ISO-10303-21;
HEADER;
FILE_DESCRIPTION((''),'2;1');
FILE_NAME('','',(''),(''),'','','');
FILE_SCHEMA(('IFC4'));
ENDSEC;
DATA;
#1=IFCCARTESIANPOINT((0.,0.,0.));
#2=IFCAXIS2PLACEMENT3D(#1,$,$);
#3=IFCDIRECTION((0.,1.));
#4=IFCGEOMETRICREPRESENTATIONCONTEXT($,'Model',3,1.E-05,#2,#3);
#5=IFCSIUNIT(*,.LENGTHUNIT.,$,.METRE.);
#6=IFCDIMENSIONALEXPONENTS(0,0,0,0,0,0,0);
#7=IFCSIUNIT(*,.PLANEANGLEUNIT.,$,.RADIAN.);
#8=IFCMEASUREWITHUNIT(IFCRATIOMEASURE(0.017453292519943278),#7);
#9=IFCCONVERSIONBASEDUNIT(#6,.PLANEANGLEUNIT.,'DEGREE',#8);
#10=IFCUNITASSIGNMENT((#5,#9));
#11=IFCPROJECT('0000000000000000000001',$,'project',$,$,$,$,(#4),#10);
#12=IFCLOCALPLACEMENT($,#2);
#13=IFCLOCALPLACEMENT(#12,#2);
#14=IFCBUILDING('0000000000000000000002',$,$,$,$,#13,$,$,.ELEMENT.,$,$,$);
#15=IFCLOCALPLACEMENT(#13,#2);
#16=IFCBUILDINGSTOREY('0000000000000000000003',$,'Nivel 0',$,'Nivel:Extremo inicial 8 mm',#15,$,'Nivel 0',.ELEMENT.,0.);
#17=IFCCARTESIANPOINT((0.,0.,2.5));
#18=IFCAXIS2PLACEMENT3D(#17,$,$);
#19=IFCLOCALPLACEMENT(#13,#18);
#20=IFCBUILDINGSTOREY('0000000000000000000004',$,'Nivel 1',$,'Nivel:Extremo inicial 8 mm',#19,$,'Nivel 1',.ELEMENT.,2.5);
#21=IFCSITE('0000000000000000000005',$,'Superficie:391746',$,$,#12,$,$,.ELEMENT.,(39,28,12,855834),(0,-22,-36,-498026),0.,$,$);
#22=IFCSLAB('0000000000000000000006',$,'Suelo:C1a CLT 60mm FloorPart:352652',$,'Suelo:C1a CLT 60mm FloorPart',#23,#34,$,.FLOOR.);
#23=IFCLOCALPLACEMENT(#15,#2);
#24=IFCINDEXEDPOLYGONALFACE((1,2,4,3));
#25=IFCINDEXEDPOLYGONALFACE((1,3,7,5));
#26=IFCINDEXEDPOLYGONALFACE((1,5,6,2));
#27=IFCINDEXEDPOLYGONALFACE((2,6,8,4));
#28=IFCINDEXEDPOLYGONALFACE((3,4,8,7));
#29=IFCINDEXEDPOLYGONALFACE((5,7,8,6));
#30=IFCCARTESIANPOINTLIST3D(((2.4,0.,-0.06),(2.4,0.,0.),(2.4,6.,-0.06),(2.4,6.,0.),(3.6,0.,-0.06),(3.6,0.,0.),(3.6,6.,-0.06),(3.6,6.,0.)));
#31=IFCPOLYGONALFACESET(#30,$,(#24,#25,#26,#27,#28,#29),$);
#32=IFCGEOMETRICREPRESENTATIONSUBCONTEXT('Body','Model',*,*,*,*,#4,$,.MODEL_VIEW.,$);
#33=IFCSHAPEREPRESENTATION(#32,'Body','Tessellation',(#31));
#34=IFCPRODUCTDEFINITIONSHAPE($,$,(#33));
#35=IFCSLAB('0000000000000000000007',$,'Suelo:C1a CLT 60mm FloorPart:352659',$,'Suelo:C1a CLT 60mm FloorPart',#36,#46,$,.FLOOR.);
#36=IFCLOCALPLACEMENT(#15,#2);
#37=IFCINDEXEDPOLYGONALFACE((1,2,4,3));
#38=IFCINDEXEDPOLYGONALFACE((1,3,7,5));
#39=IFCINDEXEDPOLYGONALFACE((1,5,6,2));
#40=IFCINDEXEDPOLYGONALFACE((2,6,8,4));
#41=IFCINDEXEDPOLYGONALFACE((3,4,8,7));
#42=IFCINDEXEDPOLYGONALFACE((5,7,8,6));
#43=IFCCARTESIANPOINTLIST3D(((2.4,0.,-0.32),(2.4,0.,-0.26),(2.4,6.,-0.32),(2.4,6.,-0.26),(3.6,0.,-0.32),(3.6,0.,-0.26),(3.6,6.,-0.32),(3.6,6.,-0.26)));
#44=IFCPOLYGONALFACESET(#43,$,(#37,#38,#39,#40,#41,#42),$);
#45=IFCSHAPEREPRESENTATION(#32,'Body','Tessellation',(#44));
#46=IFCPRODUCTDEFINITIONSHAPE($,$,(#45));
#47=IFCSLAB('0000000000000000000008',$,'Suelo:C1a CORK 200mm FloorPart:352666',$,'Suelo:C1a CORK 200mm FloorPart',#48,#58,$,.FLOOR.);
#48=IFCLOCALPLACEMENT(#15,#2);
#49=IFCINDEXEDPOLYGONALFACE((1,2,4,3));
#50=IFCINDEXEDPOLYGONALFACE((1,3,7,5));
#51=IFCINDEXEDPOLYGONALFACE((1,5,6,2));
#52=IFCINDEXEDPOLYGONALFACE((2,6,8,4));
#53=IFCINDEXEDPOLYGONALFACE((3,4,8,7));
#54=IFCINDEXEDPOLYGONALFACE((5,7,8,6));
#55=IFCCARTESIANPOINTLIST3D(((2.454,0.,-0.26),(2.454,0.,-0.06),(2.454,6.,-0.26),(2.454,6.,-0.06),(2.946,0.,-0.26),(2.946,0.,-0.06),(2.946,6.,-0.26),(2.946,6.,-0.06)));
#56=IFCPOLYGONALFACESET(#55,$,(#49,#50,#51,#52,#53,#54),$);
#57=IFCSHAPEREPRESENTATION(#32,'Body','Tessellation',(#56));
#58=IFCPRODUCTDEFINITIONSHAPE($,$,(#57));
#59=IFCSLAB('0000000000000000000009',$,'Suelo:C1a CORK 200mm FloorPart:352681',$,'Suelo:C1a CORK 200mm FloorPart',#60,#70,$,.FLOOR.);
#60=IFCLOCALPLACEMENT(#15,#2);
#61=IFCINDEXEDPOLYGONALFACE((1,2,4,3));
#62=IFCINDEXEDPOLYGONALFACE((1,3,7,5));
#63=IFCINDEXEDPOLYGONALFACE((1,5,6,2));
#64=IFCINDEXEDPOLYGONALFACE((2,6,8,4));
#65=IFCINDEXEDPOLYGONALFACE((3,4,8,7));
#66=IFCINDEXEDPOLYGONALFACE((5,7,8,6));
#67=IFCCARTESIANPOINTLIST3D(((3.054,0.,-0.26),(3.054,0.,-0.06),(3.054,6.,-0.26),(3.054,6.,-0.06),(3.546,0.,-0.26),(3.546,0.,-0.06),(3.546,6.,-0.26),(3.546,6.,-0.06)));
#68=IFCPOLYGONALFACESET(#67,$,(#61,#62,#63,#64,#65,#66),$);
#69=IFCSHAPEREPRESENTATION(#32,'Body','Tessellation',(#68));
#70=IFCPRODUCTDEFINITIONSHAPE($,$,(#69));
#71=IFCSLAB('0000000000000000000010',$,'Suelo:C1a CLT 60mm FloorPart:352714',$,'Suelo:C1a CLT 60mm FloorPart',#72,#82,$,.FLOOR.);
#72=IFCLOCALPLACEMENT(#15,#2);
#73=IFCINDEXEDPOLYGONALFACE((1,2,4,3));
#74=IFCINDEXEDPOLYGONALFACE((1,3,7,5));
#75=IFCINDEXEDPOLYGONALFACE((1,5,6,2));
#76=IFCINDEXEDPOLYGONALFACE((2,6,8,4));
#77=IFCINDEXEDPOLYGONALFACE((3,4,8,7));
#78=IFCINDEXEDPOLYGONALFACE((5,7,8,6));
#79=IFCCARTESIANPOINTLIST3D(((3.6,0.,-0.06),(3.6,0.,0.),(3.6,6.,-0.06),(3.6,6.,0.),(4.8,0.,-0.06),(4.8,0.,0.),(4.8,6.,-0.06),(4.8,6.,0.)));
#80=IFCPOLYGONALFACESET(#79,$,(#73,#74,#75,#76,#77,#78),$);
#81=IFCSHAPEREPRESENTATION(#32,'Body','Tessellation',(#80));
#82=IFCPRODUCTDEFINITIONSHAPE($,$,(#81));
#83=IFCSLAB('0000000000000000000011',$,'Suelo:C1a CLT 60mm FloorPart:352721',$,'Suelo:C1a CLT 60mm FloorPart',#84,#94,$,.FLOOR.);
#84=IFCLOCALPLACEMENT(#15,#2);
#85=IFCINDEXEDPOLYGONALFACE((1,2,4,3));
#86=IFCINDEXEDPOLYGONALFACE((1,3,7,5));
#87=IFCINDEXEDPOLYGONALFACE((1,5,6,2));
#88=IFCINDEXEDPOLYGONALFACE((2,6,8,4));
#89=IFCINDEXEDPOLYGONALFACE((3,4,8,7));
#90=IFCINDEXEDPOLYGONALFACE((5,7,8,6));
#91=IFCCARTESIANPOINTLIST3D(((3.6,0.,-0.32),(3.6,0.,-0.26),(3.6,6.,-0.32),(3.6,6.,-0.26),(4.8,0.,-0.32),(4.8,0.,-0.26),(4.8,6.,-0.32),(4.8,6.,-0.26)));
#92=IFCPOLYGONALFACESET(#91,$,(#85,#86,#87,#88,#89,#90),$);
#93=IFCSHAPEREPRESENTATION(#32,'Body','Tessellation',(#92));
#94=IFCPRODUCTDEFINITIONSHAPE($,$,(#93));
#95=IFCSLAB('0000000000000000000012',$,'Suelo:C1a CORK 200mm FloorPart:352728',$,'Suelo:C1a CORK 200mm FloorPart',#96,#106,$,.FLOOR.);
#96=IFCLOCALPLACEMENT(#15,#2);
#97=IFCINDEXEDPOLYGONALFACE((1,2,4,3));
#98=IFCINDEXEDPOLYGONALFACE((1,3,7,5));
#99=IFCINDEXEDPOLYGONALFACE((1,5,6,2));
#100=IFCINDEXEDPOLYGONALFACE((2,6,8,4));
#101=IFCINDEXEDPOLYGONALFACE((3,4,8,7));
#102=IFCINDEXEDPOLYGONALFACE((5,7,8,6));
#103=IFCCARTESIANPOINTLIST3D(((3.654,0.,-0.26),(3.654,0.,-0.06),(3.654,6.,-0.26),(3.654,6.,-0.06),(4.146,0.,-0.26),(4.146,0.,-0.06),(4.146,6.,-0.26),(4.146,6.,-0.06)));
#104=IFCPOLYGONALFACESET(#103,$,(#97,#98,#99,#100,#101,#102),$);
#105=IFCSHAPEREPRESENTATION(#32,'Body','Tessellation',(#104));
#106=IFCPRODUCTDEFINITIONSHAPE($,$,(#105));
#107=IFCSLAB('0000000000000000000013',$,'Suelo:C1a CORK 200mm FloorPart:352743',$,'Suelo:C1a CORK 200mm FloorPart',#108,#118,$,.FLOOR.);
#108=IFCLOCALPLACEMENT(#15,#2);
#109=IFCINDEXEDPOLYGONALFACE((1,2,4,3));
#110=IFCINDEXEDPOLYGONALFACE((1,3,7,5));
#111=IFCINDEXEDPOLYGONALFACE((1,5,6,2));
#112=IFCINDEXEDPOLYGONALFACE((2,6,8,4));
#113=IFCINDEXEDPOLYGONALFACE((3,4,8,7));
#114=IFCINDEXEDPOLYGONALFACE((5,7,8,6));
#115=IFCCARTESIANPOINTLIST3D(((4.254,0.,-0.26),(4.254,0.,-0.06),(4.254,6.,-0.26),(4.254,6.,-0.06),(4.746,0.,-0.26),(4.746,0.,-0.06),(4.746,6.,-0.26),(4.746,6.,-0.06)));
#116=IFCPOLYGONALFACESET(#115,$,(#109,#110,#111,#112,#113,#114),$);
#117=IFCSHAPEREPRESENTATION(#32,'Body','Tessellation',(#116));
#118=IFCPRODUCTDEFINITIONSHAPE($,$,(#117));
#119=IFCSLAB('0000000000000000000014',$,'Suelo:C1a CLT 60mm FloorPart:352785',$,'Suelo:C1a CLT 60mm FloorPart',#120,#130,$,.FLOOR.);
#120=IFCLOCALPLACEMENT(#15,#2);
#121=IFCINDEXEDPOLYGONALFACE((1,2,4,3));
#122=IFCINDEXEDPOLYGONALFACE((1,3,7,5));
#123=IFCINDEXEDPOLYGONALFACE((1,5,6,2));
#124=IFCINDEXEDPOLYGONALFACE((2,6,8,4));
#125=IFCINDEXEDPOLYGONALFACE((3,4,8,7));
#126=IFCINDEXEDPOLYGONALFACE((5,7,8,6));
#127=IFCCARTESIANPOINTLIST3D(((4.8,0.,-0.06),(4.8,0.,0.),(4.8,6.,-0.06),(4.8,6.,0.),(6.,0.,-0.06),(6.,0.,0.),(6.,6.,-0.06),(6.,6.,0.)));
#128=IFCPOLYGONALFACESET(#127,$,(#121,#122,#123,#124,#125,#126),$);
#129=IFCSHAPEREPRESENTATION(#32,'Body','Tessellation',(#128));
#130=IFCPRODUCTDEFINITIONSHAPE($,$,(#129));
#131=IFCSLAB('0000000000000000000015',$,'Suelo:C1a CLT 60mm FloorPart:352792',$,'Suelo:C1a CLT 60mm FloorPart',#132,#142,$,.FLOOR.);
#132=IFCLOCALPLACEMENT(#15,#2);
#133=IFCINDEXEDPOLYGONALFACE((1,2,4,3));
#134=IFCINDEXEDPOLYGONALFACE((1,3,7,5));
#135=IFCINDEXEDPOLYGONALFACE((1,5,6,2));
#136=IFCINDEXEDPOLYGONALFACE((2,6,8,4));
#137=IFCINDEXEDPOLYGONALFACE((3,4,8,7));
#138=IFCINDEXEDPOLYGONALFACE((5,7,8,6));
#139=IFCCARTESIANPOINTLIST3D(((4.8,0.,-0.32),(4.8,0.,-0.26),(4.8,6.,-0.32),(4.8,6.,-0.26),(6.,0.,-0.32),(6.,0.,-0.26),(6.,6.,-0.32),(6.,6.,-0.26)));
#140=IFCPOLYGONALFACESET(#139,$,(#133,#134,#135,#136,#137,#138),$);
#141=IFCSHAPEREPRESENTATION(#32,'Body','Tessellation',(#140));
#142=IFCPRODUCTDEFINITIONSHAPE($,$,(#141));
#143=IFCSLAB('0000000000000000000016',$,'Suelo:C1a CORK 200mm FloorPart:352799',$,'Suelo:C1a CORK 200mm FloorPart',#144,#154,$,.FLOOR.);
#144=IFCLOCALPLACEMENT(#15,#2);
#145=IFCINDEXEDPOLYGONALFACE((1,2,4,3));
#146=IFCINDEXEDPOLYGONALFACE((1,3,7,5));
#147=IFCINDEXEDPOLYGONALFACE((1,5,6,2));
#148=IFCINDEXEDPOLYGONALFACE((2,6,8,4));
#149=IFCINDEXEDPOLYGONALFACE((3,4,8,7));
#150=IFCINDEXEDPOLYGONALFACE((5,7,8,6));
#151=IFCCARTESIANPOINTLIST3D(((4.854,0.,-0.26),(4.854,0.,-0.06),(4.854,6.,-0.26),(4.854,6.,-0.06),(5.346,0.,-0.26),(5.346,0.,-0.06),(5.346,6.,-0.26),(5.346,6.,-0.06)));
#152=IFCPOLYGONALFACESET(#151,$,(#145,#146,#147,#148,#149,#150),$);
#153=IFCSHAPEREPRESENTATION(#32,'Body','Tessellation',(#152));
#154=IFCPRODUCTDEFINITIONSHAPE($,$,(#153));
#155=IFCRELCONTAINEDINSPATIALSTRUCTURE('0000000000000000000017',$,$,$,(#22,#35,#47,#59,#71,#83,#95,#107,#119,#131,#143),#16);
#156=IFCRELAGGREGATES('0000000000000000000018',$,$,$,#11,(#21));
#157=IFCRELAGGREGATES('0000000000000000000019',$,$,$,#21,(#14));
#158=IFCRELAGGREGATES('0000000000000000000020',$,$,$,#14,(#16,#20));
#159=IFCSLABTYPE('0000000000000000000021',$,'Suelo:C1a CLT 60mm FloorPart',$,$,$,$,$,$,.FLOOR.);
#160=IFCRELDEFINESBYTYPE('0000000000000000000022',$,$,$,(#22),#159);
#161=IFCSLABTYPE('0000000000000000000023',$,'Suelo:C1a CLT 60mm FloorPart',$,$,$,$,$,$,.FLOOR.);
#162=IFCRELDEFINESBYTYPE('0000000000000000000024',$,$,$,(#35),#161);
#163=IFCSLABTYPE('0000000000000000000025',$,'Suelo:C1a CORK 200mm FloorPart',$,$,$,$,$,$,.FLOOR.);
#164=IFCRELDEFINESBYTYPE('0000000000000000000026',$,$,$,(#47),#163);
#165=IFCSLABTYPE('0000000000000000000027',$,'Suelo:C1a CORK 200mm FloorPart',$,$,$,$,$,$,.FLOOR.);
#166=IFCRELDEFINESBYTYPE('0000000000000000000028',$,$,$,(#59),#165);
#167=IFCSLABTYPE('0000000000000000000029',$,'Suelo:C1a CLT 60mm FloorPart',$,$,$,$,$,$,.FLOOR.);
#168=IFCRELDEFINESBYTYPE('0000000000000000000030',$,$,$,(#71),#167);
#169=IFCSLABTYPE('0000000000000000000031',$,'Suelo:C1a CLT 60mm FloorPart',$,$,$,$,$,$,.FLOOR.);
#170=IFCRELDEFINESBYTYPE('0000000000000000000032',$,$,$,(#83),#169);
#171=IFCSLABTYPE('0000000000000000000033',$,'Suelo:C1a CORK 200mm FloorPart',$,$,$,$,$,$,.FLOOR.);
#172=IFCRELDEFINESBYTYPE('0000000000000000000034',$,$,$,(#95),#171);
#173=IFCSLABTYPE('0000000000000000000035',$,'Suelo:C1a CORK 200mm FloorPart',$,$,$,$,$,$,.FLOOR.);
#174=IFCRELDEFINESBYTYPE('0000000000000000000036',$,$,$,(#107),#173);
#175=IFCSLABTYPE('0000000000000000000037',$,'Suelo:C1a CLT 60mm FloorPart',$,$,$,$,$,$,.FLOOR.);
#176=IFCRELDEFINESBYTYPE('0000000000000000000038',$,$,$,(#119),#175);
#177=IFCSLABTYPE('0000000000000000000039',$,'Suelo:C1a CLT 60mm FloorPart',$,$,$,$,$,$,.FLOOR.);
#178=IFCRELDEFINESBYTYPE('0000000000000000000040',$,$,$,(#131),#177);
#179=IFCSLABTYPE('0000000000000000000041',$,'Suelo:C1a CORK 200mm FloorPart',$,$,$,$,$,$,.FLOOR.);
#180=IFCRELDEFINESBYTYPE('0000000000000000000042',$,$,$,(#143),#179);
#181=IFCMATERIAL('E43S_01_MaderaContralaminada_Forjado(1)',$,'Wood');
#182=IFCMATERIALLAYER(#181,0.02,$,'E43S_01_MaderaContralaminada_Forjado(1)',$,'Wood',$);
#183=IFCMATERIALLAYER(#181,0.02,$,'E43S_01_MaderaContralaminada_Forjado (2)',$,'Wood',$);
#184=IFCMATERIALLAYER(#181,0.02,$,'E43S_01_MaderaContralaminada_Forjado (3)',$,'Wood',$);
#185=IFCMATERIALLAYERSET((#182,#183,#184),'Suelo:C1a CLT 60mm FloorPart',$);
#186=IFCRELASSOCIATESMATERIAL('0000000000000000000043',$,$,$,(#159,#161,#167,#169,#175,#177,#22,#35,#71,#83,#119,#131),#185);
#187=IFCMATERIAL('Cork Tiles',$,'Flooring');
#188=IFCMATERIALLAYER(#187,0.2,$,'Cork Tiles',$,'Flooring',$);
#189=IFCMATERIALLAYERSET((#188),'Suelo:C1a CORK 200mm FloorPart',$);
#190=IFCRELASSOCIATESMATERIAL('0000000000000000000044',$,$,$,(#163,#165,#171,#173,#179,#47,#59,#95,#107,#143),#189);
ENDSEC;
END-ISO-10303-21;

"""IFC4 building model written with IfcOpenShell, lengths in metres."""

from ifc_helpers import new_model, entity, si_unit, converted_unit, direction, frame, frame_2d, origin, place, context, subcontext, project, spatial, rectangle, extrude, material, layer, layer_set, layer_usage, type_object, element, save


model = new_model("IFC4")

# Units and contexts
model_context = context("Model", 3, precision=1e-05, world=origin(), true_north=direction((0.0, 1.0)))
body_context = subcontext(model_context, "Body", "Model", "MODEL_VIEW")
ifc_project = project(units=[si_unit("LENGTHUNIT", "METRE"), converted_unit("PLANEANGLEUNIT", "DEGREE", entity("IfcRatioMeasure", 0.017453292519943278), si_unit("PLANEANGLEUNIT", "RADIAN"), dimensions=[0, 0, 0, 0, 0, 0, 0])], contexts=[model_context])

# Site, building, storey
site_placement = place(None, origin())
site = spatial("IfcSite", under=ifc_project, at=site_placement, Name="Superficie:391746", CompositionType="ELEMENT", RefLatitude=(39, 28, 12, 855834), RefLongitude=(0, -22, -36, -498026), RefElevation=0.0)
building_placement = place(site_placement, origin())
building = spatial("IfcBuilding", under=site, at=building_placement, CompositionType="ELEMENT")
storey_1_placement = place(building_placement, origin())
storey_1 = spatial("IfcBuildingStorey", under=building, at=storey_1_placement, Name="Nivel 0", ObjectType="Nivel:Extremo inicial 8 mm", LongName="Nivel 0", CompositionType="ELEMENT", Elevation=0.0)

# Slabs
ifc_material_1 = material(Name="E43S_01_MaderaContralaminada_Forjado(1)", Category="Wood")
ifc_layer_1 = layer(ifc_material_1, 0.02, Name="E43S_01_MaderaContralaminada_Forjado(1)", Category="Wood")
ifc_layer_2 = layer(ifc_material_1, 0.02, Name="E43S_01_MaderaContralaminada_Forjado (2)", Category="Wood")
ifc_layer_3 = layer(ifc_material_1, 0.02, Name="E43S_01_MaderaContralaminada_Forjado (3)", Category="Wood")
ifc_layer_set_1 = layer_set([ifc_layer_1, ifc_layer_2, ifc_layer_3], Name="Suelo:C1a CLT 60mm FloorPart")
ifc_material_2 = material(Name="Cork Tiles", Category="Flooring")
ifc_layer_4 = layer(ifc_material_2, 0.2, Name="Cork Tiles", Category="Flooring")
ifc_layer_set_2 = layer_set([ifc_layer_4], Name="Suelo:C1a CORK 200mm FloorPart")
ifc_layer_usage_1 = layer_usage(ifc_layer_set_1, "AXIS3", "POSITIVE", 0.0)
slab_type_1 = type_object("IfcSlabType", Name="Suelo:C1a CLT 60mm FloorPart", PredefinedType="FLOOR", material=ifc_layer_set_1)
slab_1_placement = place(storey_1_placement, origin())
element("IfcSlab", 1, at=slab_1_placement, inside=storey_1, type_object=slab_type_1, material=ifc_layer_usage_1, Name="Suelo:C1a CLT 60mm FloorPart:352652", ObjectType="Suelo:C1a CLT 60mm FloorPart", PredefinedType="FLOOR", context=body_context, shape_type="SweptSolid", body=[
    extrude(rectangle(XDim=6.0, YDim=1.2, at=frame_2d((0.0, 0.0), x_axis=(1.0, 0.0))), frame((3.0, 3.0, 0.0), z_axis=(0.0, 0.0, -1.0), x_axis=(0.0, 1.0, 0.0)), (0.0, 0.0, 1.0), 0.06),
])
ifc_layer_usage_2 = layer_usage(ifc_layer_set_1, "AXIS3", "POSITIVE", 0.0)
slab_type_2 = type_object("IfcSlabType", Name="Suelo:C1a CLT 60mm FloorPart", PredefinedType="FLOOR", material=ifc_layer_set_1)
slab_2_placement = place(storey_1_placement, origin())
element("IfcSlab", 2, at=slab_2_placement, inside=storey_1, type_object=slab_type_2, material=ifc_layer_usage_2, Name="Suelo:C1a CLT 60mm FloorPart:352659", ObjectType="Suelo:C1a CLT 60mm FloorPart", PredefinedType="FLOOR", context=body_context, shape_type="SweptSolid", body=[
    extrude(rectangle(XDim=6.0, YDim=1.2, at=frame_2d((0.0, 0.0), x_axis=(1.0, 0.0))), frame((3.0, 3.0, -0.26), z_axis=(0.0, 0.0, -1.0), x_axis=(0.0, 1.0, 0.0)), (0.0, 0.0, 1.0), 0.06),
])
ifc_layer_usage_3 = layer_usage(ifc_layer_set_2, "AXIS3", "POSITIVE", 0.0)
slab_type_3 = type_object("IfcSlabType", Name="Suelo:C1a CORK 200mm FloorPart", PredefinedType="FLOOR", material=ifc_layer_set_2)
slab_3_placement = place(storey_1_placement, origin())
element("IfcSlab", 3, at=slab_3_placement, inside=storey_1, type_object=slab_type_3, material=ifc_layer_usage_3, Name="Suelo:C1a CORK 200mm FloorPart:352666", ObjectType="Suelo:C1a CORK 200mm FloorPart", PredefinedType="FLOOR", context=body_context, shape_type="SweptSolid", body=[
    extrude(rectangle(XDim=6.0, YDim=0.492, at=frame_2d((0.0, 0.0), x_axis=(1.0, 0.0))), frame((2.7, 3.0, -0.06), z_axis=(0.0, 0.0, -1.0), x_axis=(0.0, 1.0, 0.0)), (0.0, 0.0, 1.0), 0.2),
])
ifc_layer_usage_4 = layer_usage(ifc_layer_set_2, "AXIS3", "POSITIVE", 0.0)
slab_type_4 = type_object("IfcSlabType", Name="Suelo:C1a CORK 200mm FloorPart", PredefinedType="FLOOR", material=ifc_layer_set_2)
slab_4_placement = place(storey_1_placement, origin())
element("IfcSlab", 4, at=slab_4_placement, inside=storey_1, type_object=slab_type_4, material=ifc_layer_usage_4, Name="Suelo:C1a CORK 200mm FloorPart:352681", ObjectType="Suelo:C1a CORK 200mm FloorPart", PredefinedType="FLOOR", context=body_context, shape_type="SweptSolid", body=[
    extrude(rectangle(XDim=6.0, YDim=0.492, at=frame_2d((0.0, 0.0), x_axis=(1.0, 0.0))), frame((3.3, 3.0, -0.06), z_axis=(0.0, 0.0, -1.0), x_axis=(0.0, 1.0, 0.0)), (0.0, 0.0, 1.0), 0.2),
])
ifc_layer_usage_5 = layer_usage(ifc_layer_set_1, "AXIS3", "POSITIVE", 0.0)
slab_type_5 = type_object("IfcSlabType", Name="Suelo:C1a CLT 60mm FloorPart", PredefinedType="FLOOR", material=ifc_layer_set_1)
slab_5_placement = place(storey_1_placement, origin())
element("IfcSlab", 5, at=slab_5_placement, inside=storey_1, type_object=slab_type_5, material=ifc_layer_usage_5, Name="Suelo:C1a CLT 60mm FloorPart:352714", ObjectType="Suelo:C1a CLT 60mm FloorPart", PredefinedType="FLOOR", context=body_context, shape_type="SweptSolid", body=[
    extrude(rectangle(XDim=6.0, YDim=1.2, at=frame_2d((0.0, 0.0), x_axis=(1.0, 0.0))), frame((4.2, 3.0, 0.0), z_axis=(0.0, 0.0, -1.0), x_axis=(0.0, 1.0, 0.0)), (0.0, 0.0, 1.0), 0.06),
])
ifc_layer_usage_6 = layer_usage(ifc_layer_set_1, "AXIS3", "POSITIVE", 0.0)
slab_type_6 = type_object("IfcSlabType", Name="Suelo:C1a CLT 60mm FloorPart", PredefinedType="FLOOR", material=ifc_layer_set_1)
slab_6_placement = place(storey_1_placement, origin())
element("IfcSlab", 6, at=slab_6_placement, inside=storey_1, type_object=slab_type_6, material=ifc_layer_usage_6, Name="Suelo:C1a CLT 60mm FloorPart:352721", ObjectType="Suelo:C1a CLT 60mm FloorPart", PredefinedType="FLOOR", context=body_context, shape_type="SweptSolid", body=[
    extrude(rectangle(XDim=6.0, YDim=1.2, at=frame_2d((0.0, 0.0), x_axis=(1.0, 0.0))), frame((4.2, 3.0, -0.26), z_axis=(0.0, 0.0, -1.0), x_axis=(0.0, 1.0, 0.0)), (0.0, 0.0, 1.0), 0.06),
])
ifc_layer_usage_7 = layer_usage(ifc_layer_set_2, "AXIS3", "POSITIVE", 0.0)
slab_type_7 = type_object("IfcSlabType", Name="Suelo:C1a CORK 200mm FloorPart", PredefinedType="FLOOR", material=ifc_layer_set_2)
slab_7_placement = place(storey_1_placement, origin())
element("IfcSlab", 7, at=slab_7_placement, inside=storey_1, type_object=slab_type_7, material=ifc_layer_usage_7, Name="Suelo:C1a CORK 200mm FloorPart:352728", ObjectType="Suelo:C1a CORK 200mm FloorPart", PredefinedType="FLOOR", context=body_context, shape_type="SweptSolid", body=[
    extrude(rectangle(XDim=6.0, YDim=0.492, at=frame_2d((0.0, 0.0), x_axis=(1.0, 0.0))), frame((3.9, 3.0, -0.06), z_axis=(0.0, 0.0, -1.0), x_axis=(0.0, 1.0, 0.0)), (0.0, 0.0, 1.0), 0.2),
])
ifc_layer_usage_8 = layer_usage(ifc_layer_set_2, "AXIS3", "POSITIVE", 0.0)
slab_type_8 = type_object("IfcSlabType", Name="Suelo:C1a CORK 200mm FloorPart", PredefinedType="FLOOR", material=ifc_layer_set_2)
slab_8_placement = place(storey_1_placement, origin())
element("IfcSlab", 8, at=slab_8_placement, inside=storey_1, type_object=slab_type_8, material=ifc_layer_usage_8, Name="Suelo:C1a CORK 200mm FloorPart:352743", ObjectType="Suelo:C1a CORK 200mm FloorPart", PredefinedType="FLOOR", context=body_context, shape_type="SweptSolid", body=[
    extrude(rectangle(XDim=6.0, YDim=0.492, at=frame_2d((0.0, 0.0), x_axis=(1.0, 0.0))), frame((4.5, 3.0, -0.06), z_axis=(0.0, 0.0, -1.0), x_axis=(0.0, 1.0, 0.0)), (0.0, 0.0, 1.0), 0.2),
])
ifc_layer_usage_9 = layer_usage(ifc_layer_set_1, "AXIS3", "POSITIVE", 0.0)
slab_type_9 = type_object("IfcSlabType", Name="Suelo:C1a CLT 60mm FloorPart", PredefinedType="FLOOR", material=ifc_layer_set_1)
slab_9_placement = place(storey_1_placement, origin())
element("IfcSlab", 9, at=slab_9_placement, inside=storey_1, type_object=slab_type_9, material=ifc_layer_usage_9, Name="Suelo:C1a CLT 60mm FloorPart:352785", ObjectType="Suelo:C1a CLT 60mm FloorPart", PredefinedType="FLOOR", context=body_context, shape_type="SweptSolid", body=[
    extrude(rectangle(XDim=6.0, YDim=1.2, at=frame_2d((0.0, 0.0), x_axis=(1.0, 0.0))), frame((5.4, 3.0, 0.0), z_axis=(0.0, 0.0, -1.0), x_axis=(0.0, 1.0, 0.0)), (0.0, 0.0, 1.0), 0.06),
])
ifc_layer_usage_10 = layer_usage(ifc_layer_set_1, "AXIS3", "POSITIVE", 0.0)
slab_type_10 = type_object("IfcSlabType", Name="Suelo:C1a CLT 60mm FloorPart", PredefinedType="FLOOR", material=ifc_layer_set_1)
slab_10_placement = place(storey_1_placement, origin())
element("IfcSlab", 10, at=slab_10_placement, inside=storey_1, type_object=slab_type_10, material=ifc_layer_usage_10, Name="Suelo:C1a CLT 60mm FloorPart:352792", ObjectType="Suelo:C1a CLT 60mm FloorPart", PredefinedType="FLOOR", context=body_context, shape_type="SweptSolid", body=[
    extrude(rectangle(XDim=6.0, YDim=1.2, at=frame_2d((0.0, 0.0), x_axis=(1.0, 0.0))), frame((5.4, 3.0, -0.26), z_axis=(0.0, 0.0, -1.0), x_axis=(0.0, 1.0, 0.0)), (0.0, 0.0, 1.0), 0.06),
])
ifc_layer_usage_11 = layer_usage(ifc_layer_set_2, "AXIS3", "POSITIVE", 0.0)
slab_type_11 = type_object("IfcSlabType", Name="Suelo:C1a CORK 200mm FloorPart", PredefinedType="FLOOR", material=ifc_layer_set_2)
slab_11_placement = place(storey_1_placement, origin())
element("IfcSlab", 11, at=slab_11_placement, inside=storey_1, type_object=slab_type_11, material=ifc_layer_usage_11, Name="Suelo:C1a CORK 200mm FloorPart:352799", ObjectType="Suelo:C1a CORK 200mm FloorPart", PredefinedType="FLOOR", context=body_context, shape_type="SweptSolid", body=[
    extrude(rectangle(XDim=6.0, YDim=0.492, at=frame_2d((0.0, 0.0), x_axis=(1.0, 0.0))), frame((5.1, 3.0, -0.06), z_axis=(0.0, 0.0, -1.0), x_axis=(0.0, 1.0, 0.0)), (0.0, 0.0, 1.0), 0.2),
])

# Shared definitions
storey_2_placement = place(building_placement, frame((0.0, 0.0, 2.5)))
storey_2 = spatial("IfcBuildingStorey", under=building, at=storey_2_placement, Name="Nivel 1", ObjectType="Nivel:Extremo inicial 8 mm", LongName="Nivel 1", CompositionType="ELEMENT", Elevation=2.5)

save(model, "model.ifc")
